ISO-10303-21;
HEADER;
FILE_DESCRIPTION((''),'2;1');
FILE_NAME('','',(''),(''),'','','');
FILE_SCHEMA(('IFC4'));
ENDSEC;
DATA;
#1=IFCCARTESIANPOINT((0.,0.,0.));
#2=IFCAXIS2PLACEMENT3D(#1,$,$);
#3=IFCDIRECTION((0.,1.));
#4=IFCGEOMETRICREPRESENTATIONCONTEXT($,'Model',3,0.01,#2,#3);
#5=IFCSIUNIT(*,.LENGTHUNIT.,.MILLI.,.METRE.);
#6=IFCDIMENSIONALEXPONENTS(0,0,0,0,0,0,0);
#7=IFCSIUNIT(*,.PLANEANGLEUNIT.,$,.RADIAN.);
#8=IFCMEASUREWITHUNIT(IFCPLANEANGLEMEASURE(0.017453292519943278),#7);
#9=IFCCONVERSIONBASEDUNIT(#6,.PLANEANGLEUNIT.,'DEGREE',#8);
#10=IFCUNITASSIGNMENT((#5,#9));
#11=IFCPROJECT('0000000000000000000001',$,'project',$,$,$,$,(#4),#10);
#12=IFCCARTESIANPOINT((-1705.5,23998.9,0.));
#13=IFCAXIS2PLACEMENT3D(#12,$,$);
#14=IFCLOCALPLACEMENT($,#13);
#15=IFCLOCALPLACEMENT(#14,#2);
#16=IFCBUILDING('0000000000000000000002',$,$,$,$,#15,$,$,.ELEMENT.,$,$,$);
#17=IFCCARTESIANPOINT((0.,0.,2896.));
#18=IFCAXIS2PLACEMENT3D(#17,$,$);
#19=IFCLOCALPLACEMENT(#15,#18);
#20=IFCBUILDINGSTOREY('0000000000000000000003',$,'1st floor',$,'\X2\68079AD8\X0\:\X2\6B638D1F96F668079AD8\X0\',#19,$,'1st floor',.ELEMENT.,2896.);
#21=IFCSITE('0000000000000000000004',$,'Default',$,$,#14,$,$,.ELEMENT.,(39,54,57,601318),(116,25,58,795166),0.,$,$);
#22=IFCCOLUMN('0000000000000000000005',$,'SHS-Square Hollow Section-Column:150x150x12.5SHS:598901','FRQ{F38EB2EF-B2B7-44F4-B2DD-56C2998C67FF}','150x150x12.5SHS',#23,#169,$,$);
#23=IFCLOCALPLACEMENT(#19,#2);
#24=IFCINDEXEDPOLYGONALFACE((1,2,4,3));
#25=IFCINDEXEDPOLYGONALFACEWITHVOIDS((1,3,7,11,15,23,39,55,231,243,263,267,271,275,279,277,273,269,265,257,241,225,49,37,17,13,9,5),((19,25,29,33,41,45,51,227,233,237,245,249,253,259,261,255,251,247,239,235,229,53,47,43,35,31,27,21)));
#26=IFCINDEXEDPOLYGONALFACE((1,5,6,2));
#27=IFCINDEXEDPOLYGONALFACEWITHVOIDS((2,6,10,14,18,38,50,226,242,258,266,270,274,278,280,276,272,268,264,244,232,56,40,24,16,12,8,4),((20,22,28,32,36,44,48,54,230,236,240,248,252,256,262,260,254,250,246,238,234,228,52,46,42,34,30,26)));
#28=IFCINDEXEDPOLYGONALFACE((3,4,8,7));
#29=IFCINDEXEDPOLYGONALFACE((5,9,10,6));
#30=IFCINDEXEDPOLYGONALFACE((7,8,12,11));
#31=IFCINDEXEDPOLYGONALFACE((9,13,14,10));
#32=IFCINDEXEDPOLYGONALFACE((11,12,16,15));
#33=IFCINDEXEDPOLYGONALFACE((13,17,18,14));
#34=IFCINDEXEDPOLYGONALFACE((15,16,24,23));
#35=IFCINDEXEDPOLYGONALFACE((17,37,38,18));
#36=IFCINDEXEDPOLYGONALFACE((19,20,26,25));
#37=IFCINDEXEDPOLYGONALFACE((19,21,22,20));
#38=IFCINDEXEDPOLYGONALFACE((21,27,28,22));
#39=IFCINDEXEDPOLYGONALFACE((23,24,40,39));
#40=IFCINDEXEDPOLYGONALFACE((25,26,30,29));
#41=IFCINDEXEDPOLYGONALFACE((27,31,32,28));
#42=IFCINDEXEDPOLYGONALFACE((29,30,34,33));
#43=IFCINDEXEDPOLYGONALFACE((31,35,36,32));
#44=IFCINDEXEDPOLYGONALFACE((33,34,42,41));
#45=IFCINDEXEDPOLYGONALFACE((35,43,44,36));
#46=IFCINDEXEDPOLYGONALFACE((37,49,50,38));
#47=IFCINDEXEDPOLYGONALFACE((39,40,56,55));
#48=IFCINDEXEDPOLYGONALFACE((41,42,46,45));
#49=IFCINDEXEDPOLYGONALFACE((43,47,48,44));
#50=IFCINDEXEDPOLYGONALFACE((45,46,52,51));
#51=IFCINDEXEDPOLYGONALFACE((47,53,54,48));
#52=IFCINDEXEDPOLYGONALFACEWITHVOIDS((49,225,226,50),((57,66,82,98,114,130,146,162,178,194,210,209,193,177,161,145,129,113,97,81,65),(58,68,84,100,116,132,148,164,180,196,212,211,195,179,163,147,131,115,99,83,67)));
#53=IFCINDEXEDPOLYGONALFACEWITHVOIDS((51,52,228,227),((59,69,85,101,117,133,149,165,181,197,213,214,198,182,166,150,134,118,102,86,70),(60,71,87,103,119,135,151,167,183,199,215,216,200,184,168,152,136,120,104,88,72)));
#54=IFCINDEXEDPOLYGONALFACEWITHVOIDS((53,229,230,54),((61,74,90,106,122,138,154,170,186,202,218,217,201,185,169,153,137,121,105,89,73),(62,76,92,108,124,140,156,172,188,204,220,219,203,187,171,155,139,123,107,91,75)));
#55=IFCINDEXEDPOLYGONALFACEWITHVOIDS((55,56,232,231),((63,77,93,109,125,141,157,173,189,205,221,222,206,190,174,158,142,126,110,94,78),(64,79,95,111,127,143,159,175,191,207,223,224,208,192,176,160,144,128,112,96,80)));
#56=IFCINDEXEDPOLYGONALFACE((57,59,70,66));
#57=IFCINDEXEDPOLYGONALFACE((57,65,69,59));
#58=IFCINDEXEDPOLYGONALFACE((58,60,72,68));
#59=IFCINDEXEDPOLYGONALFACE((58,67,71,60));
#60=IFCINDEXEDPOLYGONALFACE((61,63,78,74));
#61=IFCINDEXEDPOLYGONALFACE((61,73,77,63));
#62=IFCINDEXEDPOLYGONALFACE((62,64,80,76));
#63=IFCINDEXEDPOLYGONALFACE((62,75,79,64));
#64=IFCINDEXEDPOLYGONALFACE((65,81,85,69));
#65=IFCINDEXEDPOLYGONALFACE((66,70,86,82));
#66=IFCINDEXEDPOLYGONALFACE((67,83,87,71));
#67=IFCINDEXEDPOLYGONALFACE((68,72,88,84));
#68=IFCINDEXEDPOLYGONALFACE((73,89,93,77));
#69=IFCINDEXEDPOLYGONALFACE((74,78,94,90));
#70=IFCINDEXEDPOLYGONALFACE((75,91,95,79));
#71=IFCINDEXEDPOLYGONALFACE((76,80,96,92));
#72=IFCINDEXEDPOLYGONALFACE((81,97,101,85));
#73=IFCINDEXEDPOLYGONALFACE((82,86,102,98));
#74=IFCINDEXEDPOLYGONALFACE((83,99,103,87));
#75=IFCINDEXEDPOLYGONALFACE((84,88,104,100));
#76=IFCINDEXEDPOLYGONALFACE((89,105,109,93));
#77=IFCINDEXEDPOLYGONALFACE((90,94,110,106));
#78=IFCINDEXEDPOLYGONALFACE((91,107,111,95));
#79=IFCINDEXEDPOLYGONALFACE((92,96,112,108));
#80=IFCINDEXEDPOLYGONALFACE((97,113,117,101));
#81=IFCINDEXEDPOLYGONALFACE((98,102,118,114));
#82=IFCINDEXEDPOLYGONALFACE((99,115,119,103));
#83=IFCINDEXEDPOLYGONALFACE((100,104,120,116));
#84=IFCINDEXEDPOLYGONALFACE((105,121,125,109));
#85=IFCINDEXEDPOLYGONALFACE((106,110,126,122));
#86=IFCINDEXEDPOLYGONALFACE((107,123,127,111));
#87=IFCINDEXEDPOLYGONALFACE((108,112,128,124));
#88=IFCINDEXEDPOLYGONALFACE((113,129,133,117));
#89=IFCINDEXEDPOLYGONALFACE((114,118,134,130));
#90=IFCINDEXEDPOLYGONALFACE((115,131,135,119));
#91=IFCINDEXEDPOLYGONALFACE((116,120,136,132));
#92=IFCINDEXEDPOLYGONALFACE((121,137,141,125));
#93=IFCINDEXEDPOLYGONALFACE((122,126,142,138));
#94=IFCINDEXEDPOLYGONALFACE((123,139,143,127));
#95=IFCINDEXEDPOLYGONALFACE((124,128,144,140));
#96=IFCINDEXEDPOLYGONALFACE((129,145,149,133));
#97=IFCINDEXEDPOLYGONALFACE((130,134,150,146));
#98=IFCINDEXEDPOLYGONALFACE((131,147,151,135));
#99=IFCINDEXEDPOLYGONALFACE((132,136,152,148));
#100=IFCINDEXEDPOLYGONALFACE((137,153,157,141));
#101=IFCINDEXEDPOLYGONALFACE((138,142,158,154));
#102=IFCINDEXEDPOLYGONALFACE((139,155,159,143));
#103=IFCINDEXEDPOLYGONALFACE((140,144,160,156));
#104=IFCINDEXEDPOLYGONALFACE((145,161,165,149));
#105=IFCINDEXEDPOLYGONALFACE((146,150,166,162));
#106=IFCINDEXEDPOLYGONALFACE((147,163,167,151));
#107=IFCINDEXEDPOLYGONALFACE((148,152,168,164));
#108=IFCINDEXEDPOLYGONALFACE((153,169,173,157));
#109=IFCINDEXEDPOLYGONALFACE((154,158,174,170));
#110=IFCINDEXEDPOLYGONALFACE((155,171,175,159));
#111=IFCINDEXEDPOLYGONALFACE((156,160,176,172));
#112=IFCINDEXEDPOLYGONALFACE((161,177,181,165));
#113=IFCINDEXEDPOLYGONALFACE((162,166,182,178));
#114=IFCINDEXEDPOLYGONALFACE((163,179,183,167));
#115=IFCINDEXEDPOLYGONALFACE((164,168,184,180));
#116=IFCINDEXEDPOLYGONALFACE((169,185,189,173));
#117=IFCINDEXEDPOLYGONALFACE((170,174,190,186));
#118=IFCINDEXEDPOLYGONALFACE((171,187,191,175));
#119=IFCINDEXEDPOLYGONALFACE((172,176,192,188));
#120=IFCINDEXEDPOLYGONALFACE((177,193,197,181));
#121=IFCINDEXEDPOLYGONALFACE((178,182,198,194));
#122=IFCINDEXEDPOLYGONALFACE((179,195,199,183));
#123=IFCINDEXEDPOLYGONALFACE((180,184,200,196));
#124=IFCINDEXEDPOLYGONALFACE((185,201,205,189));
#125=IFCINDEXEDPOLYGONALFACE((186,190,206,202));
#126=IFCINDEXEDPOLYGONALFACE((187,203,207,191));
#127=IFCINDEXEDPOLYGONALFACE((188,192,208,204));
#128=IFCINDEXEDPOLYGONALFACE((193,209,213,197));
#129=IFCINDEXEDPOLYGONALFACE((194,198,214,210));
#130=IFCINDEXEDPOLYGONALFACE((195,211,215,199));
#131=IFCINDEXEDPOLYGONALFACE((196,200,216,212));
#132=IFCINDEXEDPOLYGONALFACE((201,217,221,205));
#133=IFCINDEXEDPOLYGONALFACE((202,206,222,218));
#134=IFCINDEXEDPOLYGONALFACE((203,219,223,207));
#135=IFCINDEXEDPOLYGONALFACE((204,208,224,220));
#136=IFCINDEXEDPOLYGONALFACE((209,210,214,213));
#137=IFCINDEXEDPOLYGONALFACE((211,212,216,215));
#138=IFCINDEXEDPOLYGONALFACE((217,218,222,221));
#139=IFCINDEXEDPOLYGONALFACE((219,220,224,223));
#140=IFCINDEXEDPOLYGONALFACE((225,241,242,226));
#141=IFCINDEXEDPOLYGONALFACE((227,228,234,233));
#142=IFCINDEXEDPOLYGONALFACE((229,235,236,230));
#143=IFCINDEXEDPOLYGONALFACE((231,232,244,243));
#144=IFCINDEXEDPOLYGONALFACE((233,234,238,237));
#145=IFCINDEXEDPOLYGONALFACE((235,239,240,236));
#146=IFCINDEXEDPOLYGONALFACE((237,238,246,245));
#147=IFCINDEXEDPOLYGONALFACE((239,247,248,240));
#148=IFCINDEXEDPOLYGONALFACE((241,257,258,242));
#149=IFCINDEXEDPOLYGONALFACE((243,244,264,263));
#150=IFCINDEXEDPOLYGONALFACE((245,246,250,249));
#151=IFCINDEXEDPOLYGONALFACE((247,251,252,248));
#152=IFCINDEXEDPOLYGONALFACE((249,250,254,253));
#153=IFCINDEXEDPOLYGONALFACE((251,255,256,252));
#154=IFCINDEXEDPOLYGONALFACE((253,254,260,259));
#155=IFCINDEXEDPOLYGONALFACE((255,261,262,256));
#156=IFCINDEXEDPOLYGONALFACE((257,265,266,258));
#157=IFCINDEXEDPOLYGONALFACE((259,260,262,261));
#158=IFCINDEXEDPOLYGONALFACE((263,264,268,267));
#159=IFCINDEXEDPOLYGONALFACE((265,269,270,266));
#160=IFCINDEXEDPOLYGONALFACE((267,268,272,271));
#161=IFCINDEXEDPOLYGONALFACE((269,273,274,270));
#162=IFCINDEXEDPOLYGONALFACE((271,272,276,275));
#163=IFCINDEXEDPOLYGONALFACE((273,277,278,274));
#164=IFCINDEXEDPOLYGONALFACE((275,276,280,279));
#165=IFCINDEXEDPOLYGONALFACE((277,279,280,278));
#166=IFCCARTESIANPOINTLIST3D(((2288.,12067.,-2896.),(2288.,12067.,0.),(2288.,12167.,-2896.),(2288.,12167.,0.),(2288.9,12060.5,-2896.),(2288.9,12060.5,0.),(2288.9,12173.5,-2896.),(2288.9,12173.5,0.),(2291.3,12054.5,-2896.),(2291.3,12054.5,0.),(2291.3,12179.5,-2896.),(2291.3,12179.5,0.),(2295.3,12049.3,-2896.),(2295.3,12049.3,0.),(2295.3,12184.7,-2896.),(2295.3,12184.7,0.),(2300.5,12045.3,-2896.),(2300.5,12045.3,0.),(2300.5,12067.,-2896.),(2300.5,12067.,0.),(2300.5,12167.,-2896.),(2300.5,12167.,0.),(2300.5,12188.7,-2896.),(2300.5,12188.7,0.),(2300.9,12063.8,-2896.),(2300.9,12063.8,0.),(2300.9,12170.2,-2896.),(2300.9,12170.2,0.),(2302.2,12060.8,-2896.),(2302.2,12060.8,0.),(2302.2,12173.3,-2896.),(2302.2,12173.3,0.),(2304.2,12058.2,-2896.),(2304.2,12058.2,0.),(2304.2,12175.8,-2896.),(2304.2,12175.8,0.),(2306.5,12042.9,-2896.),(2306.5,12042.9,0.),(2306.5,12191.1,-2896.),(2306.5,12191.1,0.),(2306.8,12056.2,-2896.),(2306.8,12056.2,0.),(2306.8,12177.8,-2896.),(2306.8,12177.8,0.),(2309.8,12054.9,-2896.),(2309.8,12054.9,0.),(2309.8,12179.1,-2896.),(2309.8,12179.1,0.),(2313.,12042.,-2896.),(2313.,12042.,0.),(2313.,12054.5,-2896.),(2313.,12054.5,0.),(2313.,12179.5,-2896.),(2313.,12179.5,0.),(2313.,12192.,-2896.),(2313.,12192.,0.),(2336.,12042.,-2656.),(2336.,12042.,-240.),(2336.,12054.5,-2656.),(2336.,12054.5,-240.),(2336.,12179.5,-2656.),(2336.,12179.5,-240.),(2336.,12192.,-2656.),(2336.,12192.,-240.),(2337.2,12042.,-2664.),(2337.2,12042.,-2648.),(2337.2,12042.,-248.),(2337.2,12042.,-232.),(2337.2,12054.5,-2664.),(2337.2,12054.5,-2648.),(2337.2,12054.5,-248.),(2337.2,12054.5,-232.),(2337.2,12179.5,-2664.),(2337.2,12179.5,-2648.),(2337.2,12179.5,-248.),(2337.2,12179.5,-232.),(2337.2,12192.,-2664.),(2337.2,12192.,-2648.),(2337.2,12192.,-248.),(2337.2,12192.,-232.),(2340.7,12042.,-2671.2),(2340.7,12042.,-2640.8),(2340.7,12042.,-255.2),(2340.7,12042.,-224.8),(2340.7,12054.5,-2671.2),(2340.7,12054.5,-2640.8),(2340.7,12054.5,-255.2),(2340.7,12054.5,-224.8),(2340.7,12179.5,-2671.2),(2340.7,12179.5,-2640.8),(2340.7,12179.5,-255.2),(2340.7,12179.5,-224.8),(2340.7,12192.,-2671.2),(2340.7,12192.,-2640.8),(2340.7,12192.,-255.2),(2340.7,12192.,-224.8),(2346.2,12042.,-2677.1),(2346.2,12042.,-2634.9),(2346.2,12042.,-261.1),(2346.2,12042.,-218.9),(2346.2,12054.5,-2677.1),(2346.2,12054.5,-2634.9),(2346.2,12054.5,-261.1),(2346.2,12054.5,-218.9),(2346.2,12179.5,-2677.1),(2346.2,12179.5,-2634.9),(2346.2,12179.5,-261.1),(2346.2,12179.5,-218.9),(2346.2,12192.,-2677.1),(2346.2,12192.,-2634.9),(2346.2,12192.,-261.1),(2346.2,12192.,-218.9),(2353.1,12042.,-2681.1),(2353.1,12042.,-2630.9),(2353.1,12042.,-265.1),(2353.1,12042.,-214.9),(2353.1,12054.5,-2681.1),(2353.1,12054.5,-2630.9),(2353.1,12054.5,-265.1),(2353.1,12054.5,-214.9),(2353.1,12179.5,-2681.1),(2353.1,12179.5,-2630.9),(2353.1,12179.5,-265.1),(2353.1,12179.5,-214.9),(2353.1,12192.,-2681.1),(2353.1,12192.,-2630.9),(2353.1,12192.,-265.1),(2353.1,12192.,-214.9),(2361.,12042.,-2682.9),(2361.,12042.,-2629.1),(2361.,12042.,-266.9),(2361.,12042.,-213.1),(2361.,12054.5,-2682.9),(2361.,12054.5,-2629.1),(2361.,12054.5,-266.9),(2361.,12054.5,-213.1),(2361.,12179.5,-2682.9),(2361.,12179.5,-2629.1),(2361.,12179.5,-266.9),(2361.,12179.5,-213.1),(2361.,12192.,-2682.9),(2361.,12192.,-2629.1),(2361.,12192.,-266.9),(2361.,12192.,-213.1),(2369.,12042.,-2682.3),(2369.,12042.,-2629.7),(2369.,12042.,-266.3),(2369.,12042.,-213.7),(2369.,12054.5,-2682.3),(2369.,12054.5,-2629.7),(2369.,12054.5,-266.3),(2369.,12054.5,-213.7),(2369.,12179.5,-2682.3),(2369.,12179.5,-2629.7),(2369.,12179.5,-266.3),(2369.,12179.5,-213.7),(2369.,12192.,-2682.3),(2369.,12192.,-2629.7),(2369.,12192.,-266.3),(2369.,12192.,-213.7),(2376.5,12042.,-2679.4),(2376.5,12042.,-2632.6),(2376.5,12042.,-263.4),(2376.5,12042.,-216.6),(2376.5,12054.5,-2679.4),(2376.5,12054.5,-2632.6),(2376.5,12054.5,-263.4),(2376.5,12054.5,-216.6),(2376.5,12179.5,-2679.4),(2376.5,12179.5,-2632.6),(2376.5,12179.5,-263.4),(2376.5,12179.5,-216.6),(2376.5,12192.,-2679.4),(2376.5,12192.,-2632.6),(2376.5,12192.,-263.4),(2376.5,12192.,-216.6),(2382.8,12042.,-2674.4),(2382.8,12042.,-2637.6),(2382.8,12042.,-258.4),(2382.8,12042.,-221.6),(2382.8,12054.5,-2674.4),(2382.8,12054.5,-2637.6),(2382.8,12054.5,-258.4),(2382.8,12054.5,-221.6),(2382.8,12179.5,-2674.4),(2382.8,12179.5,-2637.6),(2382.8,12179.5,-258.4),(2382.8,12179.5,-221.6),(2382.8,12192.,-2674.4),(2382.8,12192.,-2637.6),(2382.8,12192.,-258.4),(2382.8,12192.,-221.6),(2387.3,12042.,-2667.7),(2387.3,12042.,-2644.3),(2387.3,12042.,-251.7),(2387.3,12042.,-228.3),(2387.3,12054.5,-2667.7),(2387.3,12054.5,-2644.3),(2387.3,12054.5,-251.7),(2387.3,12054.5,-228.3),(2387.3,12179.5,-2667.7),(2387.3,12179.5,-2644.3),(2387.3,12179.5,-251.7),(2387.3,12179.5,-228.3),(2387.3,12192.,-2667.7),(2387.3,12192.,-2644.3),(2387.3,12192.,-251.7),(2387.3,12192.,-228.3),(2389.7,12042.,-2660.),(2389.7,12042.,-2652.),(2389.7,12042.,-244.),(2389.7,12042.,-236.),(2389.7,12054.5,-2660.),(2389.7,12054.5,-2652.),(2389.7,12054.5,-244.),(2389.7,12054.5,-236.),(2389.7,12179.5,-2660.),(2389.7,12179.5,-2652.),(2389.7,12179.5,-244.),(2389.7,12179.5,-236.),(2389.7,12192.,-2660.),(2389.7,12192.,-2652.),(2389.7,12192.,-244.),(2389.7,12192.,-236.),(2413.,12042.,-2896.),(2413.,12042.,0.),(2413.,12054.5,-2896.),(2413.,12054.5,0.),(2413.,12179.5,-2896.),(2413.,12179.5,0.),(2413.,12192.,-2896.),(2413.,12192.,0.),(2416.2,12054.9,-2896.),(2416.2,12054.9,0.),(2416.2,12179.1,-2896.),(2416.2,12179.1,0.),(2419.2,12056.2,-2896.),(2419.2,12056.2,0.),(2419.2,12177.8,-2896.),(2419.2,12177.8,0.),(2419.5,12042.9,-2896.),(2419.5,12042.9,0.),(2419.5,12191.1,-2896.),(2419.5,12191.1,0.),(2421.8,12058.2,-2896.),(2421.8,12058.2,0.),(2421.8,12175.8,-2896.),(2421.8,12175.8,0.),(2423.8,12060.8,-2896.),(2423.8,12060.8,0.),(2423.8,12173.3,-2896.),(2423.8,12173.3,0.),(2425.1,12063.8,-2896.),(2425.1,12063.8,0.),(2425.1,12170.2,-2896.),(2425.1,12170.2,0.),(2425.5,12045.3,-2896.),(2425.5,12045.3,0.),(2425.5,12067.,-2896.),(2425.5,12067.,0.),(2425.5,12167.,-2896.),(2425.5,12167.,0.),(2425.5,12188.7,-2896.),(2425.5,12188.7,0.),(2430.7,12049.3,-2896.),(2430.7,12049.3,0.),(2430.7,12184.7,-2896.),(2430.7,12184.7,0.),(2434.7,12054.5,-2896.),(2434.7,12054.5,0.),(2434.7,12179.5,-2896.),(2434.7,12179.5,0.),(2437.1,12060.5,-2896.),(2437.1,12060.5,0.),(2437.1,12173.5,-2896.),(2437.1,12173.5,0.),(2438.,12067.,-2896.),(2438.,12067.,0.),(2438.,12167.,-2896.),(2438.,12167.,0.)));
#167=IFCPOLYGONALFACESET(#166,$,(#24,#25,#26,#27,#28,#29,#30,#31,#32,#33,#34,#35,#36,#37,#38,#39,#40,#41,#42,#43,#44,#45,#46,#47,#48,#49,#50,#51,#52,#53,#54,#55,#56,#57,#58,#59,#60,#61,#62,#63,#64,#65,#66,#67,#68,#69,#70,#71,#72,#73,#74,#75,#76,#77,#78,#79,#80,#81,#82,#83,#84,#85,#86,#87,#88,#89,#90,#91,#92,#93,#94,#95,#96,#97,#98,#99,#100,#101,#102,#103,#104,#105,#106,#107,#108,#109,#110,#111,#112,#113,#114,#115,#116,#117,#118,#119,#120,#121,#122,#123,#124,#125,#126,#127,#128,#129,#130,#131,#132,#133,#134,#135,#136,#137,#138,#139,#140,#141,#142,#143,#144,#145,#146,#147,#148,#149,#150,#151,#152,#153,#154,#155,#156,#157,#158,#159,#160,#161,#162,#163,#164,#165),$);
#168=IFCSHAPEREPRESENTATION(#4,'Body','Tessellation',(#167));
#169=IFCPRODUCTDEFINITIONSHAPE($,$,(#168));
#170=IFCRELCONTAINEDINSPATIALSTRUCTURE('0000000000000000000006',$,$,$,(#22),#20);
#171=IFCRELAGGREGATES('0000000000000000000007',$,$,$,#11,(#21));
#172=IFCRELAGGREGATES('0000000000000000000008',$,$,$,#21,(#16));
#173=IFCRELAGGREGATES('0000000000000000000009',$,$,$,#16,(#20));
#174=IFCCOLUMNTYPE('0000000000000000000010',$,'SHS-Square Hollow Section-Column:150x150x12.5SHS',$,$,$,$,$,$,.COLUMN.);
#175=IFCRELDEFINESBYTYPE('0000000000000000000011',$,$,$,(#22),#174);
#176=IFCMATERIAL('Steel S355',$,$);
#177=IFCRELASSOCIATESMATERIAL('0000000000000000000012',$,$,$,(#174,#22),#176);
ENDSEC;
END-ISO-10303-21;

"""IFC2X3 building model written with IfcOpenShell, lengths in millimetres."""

from ifc_helpers import new_model, entity, si_unit, converted_unit, direction, frame, frame_2d, origin, origin_2d, place, context, project, spatial, circle_curve, hollow_rectangle, outline, extrude, material, type_object, element, save


model = new_model("IFC2X3")

# Units and contexts
model_context = context("Model", 3, precision=0.01, world=origin(), true_north=direction((0.0, 1.0)))
ifc_project = project(units=[si_unit("LENGTHUNIT", "METRE", prefix="MILLI"), converted_unit("PLANEANGLEUNIT", "DEGREE", entity("IfcPlaneAngleMeasure", 0.017453292519943278), si_unit("PLANEANGLEUNIT", "RADIAN"), dimensions=[0, 0, 0, 0, 0, 0, 0])], contexts=[model_context])

# Site, building, storey
site_placement = place(None, frame((-1705.5, 23998.9, 0.0)))
site = spatial("IfcSite", under=ifc_project, at=site_placement, Name="Default", CompositionType="ELEMENT", RefLatitude=(39, 54, 57, 601318), RefLongitude=(116, 25, 58, 795166), RefElevation=0.0)
building_placement = place(site_placement, origin())
building = spatial("IfcBuilding", under=site, at=building_placement, CompositionType="ELEMENT")
storey_placement = place(building_placement, frame((0.0, 0.0, 2896.0)))
storey = spatial("IfcBuildingStorey", under=building, at=storey_placement, Name="1st floor", ObjectType="标高:正负零标高", LongName="1st floor", CompositionType="ELEMENT", Elevation=2896.0)

# Shared definitions
ifc_material_1 = material(Name="Steel S355")

# Column, openings
column_type_1 = type_object("IfcColumnType", Name="SHS-Square Hollow Section-Column:150x150x12.5SHS", PredefinedType="COLUMN", material=ifc_material_1)
column_1_placement = place(storey_placement, frame((2363.0, 12117.0, 0.0), z_axis=(0.0, 0.0, 1.0), x_axis=(0.0, -1.0, 0.0)))
column_1 = element("IfcColumn", 1, at=column_1_placement, inside=storey, type_object=column_type_1, material=ifc_material_1, Name="SHS-Square Hollow Section-Column:150x150x12.5SHS:598901", Description="FRQ{F38EB2EF-B2B7-44F4-B2DD-56C2998C67FF}", ObjectType="150x150x12.5SHS", context=model_context, shape_type="SweptSolid", body=[
    extrude(hollow_rectangle(XDim=150.0, YDim=150.0, WallThickness=12.5, InnerFilletRadius=12.5, OuterFilletRadius=25.0, at=origin_2d()), origin(), (0.0, 0.0, -1.0), 2896.0),
])
opening_1_placement = place(column_1_placement, frame((175.1, 0.0, 0.0), z_axis=(-1.0, 0.0, 0.0), x_axis=(0.0, -1.0, 0.0)))
element("IfcOpeningElement", 2, at=opening_1_placement, cuts=column_1, ObjectType="Opening", context=model_context, shape_type="SweptSolid", body=[
    extrude(outline(circle_curve(frame_2d((0.0, -240.0), x_axis=(1.0, 0.0)), 27.0)), origin(), (0.0, 0.0, 1.0), 350.2),
])
opening_2_placement = place(column_1_placement, frame((175.1, 0.0, -2896.0), z_axis=(-1.0, 0.0, 0.0), x_axis=(0.0, -1.0, 0.0)))
element("IfcOpeningElement", 3, at=opening_2_placement, cuts=column_1, ObjectType="Opening", context=model_context, shape_type="SweptSolid", body=[
    extrude(outline(circle_curve(frame_2d((0.0, 240.0), x_axis=(1.0, 0.0)), 27.0)), origin(), (0.0, 0.0, 1.0), 350.2),
])

save(model, "model.ifc")
